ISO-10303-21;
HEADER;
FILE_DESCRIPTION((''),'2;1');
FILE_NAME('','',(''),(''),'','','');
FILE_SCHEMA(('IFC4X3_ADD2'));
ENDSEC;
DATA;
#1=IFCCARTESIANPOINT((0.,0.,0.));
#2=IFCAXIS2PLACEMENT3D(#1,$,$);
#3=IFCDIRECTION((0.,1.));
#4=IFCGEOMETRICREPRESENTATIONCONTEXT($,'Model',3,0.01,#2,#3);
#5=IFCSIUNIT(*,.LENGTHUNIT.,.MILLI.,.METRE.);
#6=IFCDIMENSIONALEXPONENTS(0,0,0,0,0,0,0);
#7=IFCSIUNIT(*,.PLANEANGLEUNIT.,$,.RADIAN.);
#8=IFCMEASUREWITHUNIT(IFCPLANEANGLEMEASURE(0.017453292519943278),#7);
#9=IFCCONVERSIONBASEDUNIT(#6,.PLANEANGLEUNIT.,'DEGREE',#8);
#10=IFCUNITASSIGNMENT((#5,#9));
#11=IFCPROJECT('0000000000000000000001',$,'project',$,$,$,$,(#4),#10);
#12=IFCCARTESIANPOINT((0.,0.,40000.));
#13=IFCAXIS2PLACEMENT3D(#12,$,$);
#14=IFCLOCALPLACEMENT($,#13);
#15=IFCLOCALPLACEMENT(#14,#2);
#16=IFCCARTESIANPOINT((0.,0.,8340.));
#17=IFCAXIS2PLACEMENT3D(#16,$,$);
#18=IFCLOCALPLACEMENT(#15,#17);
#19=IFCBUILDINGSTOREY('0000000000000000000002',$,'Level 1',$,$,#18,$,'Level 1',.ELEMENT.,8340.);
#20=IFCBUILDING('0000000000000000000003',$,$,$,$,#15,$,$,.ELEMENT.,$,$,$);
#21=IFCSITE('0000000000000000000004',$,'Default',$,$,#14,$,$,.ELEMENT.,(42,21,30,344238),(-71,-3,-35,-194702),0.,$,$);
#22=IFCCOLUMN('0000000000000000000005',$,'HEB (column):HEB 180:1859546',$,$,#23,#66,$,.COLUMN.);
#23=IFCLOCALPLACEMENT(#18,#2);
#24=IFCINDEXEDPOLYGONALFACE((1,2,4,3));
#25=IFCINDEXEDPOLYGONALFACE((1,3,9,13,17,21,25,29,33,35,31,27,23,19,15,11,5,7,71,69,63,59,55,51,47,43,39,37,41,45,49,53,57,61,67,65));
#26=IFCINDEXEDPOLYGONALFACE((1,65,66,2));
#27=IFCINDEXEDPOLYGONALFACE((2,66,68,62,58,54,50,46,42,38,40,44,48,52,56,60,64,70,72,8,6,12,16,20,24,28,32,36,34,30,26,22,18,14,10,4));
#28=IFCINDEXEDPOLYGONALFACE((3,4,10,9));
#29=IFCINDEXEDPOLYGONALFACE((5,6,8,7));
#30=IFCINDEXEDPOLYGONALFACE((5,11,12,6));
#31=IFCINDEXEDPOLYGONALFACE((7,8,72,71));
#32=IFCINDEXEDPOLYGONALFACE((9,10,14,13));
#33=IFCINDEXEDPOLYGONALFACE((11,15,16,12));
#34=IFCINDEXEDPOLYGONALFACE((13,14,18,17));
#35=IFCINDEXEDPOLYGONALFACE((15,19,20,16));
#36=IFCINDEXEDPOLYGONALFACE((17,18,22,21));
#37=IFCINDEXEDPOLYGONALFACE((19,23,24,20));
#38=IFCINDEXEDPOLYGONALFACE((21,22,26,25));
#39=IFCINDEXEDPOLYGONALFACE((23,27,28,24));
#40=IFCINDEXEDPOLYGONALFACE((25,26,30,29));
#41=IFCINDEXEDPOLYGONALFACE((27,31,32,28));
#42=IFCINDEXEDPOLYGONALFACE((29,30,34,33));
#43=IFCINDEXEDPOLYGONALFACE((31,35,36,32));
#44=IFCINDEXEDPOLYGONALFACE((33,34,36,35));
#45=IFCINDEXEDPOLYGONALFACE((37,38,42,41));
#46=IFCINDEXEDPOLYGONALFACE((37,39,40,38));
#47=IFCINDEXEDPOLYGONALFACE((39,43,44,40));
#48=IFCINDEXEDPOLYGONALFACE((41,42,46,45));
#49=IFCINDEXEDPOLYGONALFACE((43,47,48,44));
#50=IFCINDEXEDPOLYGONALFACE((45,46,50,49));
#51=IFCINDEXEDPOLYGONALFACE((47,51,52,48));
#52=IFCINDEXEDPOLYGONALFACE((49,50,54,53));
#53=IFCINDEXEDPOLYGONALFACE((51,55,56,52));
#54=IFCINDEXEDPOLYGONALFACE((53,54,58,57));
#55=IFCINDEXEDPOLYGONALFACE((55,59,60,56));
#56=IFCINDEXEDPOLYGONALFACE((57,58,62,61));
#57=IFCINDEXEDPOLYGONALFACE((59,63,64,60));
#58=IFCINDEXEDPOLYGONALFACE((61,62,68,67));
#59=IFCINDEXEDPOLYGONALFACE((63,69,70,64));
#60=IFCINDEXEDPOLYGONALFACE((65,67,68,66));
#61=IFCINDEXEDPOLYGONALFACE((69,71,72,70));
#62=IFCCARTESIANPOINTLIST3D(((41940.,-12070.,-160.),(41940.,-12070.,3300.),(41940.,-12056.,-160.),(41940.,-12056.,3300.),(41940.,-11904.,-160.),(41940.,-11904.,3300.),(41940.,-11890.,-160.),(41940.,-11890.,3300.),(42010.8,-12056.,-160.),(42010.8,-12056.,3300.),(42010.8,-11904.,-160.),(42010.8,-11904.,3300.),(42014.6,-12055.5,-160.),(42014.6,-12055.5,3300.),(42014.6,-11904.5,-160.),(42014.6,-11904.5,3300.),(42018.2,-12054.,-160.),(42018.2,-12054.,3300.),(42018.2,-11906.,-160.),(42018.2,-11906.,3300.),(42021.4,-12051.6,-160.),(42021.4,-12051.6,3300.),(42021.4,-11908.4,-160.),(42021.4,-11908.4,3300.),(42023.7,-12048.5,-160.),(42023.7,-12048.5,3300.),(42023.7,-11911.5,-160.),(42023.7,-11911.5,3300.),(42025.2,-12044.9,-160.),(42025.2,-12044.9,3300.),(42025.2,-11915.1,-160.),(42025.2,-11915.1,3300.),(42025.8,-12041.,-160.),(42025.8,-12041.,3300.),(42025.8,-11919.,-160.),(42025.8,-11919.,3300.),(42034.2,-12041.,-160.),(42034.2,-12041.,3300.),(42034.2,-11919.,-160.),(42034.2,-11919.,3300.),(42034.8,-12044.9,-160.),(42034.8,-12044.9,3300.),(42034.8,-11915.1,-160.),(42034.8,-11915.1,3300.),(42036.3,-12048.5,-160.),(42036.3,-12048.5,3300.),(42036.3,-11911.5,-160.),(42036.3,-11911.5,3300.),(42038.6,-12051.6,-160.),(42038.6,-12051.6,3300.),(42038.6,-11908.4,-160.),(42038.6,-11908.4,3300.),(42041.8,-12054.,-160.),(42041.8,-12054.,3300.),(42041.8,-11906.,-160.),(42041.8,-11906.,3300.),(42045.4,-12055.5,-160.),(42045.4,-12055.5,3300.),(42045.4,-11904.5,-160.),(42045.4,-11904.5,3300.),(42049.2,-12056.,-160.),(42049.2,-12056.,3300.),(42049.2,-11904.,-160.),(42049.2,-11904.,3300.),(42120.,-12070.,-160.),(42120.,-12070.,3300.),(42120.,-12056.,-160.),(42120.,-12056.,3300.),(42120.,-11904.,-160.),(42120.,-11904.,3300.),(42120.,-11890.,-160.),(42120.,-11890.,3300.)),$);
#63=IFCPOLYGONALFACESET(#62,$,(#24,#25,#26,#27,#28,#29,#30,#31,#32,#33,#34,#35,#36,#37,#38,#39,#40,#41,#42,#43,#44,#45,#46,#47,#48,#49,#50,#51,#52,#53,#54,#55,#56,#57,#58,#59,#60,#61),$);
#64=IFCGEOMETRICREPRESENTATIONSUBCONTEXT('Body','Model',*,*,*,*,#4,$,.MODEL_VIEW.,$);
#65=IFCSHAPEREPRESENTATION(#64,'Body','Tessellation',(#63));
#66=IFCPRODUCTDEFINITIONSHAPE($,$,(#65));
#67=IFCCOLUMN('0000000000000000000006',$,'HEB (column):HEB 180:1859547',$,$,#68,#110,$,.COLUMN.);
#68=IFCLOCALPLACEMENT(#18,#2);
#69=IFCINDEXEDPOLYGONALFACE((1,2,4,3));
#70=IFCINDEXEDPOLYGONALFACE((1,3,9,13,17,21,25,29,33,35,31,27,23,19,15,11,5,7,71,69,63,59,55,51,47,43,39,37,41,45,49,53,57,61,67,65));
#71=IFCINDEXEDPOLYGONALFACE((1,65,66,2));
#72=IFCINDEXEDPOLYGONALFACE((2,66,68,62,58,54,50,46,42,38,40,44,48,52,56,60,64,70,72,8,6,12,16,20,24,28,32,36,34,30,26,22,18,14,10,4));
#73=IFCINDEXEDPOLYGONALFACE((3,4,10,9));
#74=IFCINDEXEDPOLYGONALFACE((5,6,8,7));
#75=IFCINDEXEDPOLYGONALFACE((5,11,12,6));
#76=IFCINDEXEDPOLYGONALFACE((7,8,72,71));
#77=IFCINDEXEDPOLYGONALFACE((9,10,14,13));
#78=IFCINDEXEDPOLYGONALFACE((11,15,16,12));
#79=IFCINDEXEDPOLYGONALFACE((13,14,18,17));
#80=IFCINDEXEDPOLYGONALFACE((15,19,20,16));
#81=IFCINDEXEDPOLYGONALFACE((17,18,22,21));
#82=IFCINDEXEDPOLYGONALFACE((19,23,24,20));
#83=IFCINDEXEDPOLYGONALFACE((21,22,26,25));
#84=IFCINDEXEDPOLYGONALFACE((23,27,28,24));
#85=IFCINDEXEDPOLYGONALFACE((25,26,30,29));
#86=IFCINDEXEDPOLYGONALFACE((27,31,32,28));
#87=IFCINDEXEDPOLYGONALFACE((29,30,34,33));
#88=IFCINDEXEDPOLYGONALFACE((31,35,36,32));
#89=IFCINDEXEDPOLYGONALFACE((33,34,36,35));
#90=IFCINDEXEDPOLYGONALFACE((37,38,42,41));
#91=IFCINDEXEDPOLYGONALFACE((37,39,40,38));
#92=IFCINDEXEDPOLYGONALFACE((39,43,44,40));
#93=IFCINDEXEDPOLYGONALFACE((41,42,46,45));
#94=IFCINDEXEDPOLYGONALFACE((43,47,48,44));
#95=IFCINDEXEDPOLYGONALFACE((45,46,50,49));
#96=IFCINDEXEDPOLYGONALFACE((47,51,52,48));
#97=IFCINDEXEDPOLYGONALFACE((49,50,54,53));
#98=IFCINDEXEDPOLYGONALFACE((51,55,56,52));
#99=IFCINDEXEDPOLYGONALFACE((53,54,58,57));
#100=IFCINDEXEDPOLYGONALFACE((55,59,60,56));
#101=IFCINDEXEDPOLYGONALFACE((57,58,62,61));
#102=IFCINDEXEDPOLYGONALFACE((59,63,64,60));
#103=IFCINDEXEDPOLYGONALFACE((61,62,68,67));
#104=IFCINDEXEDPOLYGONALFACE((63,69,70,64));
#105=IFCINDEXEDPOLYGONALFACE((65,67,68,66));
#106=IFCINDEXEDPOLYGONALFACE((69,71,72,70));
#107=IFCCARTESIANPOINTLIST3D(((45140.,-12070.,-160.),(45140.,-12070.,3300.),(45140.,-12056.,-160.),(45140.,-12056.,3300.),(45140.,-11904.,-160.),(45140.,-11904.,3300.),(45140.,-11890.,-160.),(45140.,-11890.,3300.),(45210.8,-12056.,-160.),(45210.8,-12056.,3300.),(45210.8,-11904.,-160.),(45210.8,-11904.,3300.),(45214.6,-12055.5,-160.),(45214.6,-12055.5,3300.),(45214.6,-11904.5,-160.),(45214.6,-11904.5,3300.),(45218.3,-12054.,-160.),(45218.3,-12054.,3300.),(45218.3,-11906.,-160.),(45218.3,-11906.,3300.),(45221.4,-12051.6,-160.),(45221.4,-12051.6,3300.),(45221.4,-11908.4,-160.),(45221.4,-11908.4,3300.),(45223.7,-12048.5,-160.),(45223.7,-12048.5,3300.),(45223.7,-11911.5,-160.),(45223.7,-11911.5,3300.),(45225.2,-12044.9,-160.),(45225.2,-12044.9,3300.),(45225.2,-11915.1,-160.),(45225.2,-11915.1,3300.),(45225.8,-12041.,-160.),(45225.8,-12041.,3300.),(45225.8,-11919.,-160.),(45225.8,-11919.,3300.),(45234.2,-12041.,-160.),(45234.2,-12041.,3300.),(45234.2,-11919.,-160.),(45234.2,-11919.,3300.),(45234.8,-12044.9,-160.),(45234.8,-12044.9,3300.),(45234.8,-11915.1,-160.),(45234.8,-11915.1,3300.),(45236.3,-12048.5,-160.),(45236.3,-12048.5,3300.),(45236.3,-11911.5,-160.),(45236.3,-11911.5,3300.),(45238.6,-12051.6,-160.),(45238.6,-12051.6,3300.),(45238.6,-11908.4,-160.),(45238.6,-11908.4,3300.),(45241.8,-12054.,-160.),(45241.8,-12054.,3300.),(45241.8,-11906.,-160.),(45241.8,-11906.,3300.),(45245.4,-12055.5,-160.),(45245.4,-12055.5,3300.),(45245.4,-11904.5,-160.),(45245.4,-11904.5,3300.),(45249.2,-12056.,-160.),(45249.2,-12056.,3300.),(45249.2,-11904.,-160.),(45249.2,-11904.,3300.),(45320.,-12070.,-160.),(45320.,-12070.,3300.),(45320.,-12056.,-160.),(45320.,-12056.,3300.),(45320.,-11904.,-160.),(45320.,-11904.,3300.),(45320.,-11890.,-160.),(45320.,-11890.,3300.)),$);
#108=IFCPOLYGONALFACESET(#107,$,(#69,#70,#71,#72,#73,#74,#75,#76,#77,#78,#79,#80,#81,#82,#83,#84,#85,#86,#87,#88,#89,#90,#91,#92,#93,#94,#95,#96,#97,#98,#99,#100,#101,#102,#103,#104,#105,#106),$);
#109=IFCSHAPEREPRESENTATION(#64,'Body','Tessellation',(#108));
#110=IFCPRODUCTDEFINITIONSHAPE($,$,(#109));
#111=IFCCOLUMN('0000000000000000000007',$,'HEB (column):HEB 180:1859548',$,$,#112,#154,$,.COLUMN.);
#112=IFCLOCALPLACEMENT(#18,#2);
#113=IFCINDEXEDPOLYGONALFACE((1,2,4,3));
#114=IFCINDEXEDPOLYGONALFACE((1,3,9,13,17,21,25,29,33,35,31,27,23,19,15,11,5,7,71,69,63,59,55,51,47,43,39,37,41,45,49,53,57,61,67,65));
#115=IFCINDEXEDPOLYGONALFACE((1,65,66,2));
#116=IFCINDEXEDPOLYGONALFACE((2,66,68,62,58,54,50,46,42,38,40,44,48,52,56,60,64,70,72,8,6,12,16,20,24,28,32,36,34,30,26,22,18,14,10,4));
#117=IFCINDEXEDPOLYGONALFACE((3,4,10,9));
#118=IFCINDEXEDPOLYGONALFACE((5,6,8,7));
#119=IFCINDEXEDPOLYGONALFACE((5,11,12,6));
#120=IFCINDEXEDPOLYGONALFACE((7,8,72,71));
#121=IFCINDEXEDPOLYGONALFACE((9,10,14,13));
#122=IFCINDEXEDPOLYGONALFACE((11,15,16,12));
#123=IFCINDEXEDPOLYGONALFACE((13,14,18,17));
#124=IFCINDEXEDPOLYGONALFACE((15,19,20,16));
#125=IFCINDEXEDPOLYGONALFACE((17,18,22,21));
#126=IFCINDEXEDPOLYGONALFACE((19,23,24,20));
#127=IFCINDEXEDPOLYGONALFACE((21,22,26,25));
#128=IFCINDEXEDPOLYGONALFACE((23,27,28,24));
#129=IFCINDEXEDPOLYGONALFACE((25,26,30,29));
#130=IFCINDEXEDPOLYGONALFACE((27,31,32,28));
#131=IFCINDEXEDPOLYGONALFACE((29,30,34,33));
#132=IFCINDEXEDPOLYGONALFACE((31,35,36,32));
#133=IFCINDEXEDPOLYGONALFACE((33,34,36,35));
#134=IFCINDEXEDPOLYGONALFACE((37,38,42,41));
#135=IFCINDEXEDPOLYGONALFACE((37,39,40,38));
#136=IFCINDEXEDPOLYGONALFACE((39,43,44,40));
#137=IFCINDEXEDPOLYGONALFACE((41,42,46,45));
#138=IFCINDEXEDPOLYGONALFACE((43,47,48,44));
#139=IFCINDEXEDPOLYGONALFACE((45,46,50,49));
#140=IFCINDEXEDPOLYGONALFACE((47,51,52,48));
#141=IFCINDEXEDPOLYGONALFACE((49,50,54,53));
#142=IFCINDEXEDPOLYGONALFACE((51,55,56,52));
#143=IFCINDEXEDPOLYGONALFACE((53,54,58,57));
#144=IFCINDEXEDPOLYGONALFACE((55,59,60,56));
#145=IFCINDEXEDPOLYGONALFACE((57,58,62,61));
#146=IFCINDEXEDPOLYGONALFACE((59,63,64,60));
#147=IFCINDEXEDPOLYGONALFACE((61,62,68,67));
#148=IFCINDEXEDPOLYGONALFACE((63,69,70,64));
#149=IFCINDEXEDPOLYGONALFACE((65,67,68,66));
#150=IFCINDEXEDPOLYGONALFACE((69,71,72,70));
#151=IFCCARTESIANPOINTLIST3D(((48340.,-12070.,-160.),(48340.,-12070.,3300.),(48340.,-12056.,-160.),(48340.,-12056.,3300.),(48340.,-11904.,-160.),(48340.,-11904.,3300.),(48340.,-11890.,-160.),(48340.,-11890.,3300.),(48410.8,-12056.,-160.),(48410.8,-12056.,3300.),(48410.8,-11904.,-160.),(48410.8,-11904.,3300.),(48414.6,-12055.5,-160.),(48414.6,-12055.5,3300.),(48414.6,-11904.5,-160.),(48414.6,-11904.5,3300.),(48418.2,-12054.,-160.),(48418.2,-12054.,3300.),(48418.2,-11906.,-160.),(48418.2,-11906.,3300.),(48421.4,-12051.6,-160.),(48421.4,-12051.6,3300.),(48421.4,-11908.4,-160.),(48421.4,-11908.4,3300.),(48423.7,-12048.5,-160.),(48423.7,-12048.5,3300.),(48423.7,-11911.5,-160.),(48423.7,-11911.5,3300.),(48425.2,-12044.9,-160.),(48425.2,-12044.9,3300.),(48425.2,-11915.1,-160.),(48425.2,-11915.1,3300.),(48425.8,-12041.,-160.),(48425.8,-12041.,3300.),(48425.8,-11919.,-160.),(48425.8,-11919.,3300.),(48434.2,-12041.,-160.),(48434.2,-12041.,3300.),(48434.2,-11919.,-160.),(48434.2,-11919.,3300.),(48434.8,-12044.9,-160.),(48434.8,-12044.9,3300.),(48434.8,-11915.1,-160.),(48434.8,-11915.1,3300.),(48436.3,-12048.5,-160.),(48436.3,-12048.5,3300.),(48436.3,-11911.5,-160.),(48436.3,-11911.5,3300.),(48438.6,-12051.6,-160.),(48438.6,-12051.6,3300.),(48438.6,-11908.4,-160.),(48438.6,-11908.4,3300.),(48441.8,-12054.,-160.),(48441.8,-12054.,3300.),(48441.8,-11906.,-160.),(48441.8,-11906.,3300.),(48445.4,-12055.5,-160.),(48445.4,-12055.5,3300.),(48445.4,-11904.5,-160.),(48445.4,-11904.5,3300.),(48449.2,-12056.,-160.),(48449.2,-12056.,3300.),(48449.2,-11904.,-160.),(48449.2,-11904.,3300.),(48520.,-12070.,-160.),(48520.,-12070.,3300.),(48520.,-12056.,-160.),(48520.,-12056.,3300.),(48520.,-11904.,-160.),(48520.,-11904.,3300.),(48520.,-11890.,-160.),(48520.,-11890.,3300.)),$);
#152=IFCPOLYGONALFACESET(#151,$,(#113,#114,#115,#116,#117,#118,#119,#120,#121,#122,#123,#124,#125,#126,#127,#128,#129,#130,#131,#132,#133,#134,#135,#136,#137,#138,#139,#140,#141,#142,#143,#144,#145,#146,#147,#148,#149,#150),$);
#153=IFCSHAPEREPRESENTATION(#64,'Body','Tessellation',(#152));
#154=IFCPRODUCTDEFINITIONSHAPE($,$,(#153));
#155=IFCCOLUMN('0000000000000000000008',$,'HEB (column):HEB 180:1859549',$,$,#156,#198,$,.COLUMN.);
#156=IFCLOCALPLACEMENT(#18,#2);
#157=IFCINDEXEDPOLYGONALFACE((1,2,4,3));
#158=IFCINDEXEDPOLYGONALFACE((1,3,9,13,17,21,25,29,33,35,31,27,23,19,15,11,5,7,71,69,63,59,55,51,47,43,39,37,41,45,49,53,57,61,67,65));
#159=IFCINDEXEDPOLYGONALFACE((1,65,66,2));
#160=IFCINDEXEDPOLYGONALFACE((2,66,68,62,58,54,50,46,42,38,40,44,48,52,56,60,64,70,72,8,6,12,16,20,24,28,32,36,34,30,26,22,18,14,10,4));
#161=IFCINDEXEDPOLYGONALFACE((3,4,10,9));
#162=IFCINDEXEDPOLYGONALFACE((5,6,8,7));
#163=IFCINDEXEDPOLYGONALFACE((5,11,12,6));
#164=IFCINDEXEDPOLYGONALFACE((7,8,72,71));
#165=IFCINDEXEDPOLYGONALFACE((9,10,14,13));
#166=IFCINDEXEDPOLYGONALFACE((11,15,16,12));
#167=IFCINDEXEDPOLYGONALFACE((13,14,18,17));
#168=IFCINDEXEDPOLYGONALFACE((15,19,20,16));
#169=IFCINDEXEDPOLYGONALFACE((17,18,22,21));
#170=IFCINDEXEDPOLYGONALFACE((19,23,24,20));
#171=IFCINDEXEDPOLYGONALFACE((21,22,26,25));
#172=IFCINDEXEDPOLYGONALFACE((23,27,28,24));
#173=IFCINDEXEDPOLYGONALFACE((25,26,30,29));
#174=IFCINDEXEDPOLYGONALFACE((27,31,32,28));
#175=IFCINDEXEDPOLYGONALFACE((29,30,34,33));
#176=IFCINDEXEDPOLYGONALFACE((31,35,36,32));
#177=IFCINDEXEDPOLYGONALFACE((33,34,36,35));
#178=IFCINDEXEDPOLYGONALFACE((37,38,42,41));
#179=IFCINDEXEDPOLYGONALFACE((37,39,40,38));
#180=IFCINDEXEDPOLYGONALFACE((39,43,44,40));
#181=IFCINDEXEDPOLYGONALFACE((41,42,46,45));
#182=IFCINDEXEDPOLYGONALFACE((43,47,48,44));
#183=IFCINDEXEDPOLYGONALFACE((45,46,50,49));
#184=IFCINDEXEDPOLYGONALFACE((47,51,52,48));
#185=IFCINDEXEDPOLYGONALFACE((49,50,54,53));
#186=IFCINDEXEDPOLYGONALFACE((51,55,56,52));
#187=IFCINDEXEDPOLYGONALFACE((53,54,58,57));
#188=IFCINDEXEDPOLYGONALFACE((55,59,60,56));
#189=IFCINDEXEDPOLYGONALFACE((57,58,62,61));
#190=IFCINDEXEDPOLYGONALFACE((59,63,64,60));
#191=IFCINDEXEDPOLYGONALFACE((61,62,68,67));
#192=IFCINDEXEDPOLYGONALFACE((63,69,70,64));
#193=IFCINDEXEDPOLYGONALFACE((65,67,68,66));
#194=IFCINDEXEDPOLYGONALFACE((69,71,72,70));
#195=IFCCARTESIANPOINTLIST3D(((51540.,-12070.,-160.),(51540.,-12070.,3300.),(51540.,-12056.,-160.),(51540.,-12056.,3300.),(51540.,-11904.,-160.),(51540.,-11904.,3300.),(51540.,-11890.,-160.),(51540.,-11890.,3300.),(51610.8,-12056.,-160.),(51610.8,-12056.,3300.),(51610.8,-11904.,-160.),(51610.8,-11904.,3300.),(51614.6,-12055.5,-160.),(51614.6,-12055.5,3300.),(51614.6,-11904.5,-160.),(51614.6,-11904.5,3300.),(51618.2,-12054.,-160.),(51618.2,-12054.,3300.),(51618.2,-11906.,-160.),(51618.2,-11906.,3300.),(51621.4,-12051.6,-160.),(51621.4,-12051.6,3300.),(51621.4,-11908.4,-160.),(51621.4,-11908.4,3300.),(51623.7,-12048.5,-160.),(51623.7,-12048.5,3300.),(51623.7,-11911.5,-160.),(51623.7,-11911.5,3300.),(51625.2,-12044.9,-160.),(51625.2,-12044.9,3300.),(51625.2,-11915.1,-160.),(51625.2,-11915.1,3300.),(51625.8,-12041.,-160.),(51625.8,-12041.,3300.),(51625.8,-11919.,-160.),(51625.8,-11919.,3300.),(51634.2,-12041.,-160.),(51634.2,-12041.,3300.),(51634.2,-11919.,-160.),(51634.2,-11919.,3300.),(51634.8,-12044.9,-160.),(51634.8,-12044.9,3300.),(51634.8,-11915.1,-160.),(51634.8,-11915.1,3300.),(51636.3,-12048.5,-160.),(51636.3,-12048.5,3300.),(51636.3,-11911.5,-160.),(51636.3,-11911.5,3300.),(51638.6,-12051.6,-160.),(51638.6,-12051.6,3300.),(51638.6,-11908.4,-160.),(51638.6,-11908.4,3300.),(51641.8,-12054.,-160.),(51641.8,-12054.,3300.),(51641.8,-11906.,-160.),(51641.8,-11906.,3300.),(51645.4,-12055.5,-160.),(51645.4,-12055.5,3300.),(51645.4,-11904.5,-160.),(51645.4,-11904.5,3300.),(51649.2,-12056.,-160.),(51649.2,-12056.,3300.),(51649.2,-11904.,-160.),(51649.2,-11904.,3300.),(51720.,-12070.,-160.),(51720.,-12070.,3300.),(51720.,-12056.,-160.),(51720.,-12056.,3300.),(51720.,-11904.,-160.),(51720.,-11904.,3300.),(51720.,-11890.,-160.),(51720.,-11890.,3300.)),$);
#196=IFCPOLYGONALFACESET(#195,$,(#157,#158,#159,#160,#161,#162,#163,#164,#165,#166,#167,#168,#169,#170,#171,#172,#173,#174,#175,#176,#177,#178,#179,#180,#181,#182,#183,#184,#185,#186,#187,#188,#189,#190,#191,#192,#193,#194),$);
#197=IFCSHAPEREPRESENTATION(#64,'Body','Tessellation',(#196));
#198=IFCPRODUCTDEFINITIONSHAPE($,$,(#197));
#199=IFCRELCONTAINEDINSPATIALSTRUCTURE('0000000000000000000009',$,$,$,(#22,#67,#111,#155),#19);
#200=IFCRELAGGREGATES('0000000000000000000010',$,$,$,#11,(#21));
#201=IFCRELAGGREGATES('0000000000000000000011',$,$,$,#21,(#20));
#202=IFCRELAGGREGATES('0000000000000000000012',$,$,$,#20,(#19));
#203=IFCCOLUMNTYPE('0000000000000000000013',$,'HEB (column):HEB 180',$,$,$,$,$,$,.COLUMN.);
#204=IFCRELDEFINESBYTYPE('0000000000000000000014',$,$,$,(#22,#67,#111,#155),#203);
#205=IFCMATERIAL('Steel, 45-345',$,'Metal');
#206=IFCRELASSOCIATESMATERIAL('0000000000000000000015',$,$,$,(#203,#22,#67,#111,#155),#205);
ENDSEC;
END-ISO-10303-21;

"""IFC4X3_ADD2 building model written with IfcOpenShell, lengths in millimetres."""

from ifc_helpers import new_model, entity, si_unit, converted_unit, direction, frame, origin, origin_2d_with_axis, place, context, subcontext, project, spatial, i_section, extrude, source, transform, mapped, material, material_profile, profile_set, profile_usage, type_object, type_shapes, element, save


model = new_model("IFC4X3_ADD2")

# Units and contexts
model_context = context("Model", 3, precision=0.01, world=origin(), true_north=direction((0.0, 1.0)))
body_context = subcontext(model_context, "Body", "Model", "MODEL_VIEW")
ifc_project = project(units=[si_unit("LENGTHUNIT", "METRE", prefix="MILLI"), converted_unit("PLANEANGLEUNIT", "DEGREE", entity("IfcPlaneAngleMeasure", 0.017453292519943278), si_unit("PLANEANGLEUNIT", "RADIAN"), dimensions=[0, 0, 0, 0, 0, 0, 0])], contexts=[model_context])

# Site, building, storey
site_placement = place(None, frame((0.0, 0.0, 40000.0)))
site = spatial("IfcSite", under=ifc_project, at=site_placement, Name="Default", CompositionType="ELEMENT", RefLatitude=(42, 21, 30, 344238), RefLongitude=(-71, -3, -35, -194702), RefElevation=0.0)
building_placement = place(site_placement, origin())
building = spatial("IfcBuilding", under=site, at=building_placement, CompositionType="ELEMENT")
storey_placement = place(building_placement, frame((0.0, 0.0, 8340.0)))
storey = spatial("IfcBuildingStorey", under=building, at=storey_placement, Name="Level 1", LongName="Level 1", CompositionType="ELEMENT", Elevation=8340.0)

# Columns
ifc_material = material(Name="Steel, 45-345", Category="Metal")
ifc_material_profile_1 = material_profile(ifc_material, i_section(OverallWidth=180.0, OverallDepth=180.0, WebThickness=8.5, FlangeThickness=14.0, FilletRadius=15.0, at=origin_2d_with_axis()), Name="HEB 180")
ifc_profile_set_1 = profile_set([ifc_material_profile_1], Name="HEB 180")
ifc_profile_usage_1 = profile_usage(ifc_profile_set_1)
column_type_1 = type_object("IfcColumnType", Name="HEB (column):HEB 180", PredefinedType="COLUMN", material=ifc_profile_set_1)
shared_shape_1 = source(origin(), body_context, "Body", "SweptSolid", [
    extrude(i_section(OverallWidth=180.0, OverallDepth=180.0, WebThickness=8.5, FlangeThickness=14.0, FilletRadius=15.0, at=origin_2d_with_axis()), frame((0.0, 0.0, 8180.0), z_axis=(0.0, 0.0, 1.0), x_axis=(-1.0, 0.0, 0.0)), (0.0, 0.0, 1.0), 3460.0),
])
type_shapes(column_type_1, [shared_shape_1])
for number, where, name in (
    (1, (42030.0, -11980.0, -8340.0), "HEB (column):HEB 180:1859546"),
    (2, (45230.0, -11980.0, -8340.0), "HEB (column):HEB 180:1859547"),
    (3, (48430.0, -11980.0, -8340.0), "HEB (column):HEB 180:1859548"),
    (4, (51630.0, -11980.0, -8340.0), "HEB (column):HEB 180:1859549"),
):
    element("IfcColumn", number, at=place(storey_placement, frame(where)), inside=storey, type_object=column_type_1, material=ifc_profile_usage_1, Name=name, PredefinedType="COLUMN", context=body_context, shape_type="MappedRepresentation", body=[
        mapped(shared_shape_1, transform((0.0, 0.0, 0.0), scale=1.0)),
    ])

save(model, "model.ifc")
